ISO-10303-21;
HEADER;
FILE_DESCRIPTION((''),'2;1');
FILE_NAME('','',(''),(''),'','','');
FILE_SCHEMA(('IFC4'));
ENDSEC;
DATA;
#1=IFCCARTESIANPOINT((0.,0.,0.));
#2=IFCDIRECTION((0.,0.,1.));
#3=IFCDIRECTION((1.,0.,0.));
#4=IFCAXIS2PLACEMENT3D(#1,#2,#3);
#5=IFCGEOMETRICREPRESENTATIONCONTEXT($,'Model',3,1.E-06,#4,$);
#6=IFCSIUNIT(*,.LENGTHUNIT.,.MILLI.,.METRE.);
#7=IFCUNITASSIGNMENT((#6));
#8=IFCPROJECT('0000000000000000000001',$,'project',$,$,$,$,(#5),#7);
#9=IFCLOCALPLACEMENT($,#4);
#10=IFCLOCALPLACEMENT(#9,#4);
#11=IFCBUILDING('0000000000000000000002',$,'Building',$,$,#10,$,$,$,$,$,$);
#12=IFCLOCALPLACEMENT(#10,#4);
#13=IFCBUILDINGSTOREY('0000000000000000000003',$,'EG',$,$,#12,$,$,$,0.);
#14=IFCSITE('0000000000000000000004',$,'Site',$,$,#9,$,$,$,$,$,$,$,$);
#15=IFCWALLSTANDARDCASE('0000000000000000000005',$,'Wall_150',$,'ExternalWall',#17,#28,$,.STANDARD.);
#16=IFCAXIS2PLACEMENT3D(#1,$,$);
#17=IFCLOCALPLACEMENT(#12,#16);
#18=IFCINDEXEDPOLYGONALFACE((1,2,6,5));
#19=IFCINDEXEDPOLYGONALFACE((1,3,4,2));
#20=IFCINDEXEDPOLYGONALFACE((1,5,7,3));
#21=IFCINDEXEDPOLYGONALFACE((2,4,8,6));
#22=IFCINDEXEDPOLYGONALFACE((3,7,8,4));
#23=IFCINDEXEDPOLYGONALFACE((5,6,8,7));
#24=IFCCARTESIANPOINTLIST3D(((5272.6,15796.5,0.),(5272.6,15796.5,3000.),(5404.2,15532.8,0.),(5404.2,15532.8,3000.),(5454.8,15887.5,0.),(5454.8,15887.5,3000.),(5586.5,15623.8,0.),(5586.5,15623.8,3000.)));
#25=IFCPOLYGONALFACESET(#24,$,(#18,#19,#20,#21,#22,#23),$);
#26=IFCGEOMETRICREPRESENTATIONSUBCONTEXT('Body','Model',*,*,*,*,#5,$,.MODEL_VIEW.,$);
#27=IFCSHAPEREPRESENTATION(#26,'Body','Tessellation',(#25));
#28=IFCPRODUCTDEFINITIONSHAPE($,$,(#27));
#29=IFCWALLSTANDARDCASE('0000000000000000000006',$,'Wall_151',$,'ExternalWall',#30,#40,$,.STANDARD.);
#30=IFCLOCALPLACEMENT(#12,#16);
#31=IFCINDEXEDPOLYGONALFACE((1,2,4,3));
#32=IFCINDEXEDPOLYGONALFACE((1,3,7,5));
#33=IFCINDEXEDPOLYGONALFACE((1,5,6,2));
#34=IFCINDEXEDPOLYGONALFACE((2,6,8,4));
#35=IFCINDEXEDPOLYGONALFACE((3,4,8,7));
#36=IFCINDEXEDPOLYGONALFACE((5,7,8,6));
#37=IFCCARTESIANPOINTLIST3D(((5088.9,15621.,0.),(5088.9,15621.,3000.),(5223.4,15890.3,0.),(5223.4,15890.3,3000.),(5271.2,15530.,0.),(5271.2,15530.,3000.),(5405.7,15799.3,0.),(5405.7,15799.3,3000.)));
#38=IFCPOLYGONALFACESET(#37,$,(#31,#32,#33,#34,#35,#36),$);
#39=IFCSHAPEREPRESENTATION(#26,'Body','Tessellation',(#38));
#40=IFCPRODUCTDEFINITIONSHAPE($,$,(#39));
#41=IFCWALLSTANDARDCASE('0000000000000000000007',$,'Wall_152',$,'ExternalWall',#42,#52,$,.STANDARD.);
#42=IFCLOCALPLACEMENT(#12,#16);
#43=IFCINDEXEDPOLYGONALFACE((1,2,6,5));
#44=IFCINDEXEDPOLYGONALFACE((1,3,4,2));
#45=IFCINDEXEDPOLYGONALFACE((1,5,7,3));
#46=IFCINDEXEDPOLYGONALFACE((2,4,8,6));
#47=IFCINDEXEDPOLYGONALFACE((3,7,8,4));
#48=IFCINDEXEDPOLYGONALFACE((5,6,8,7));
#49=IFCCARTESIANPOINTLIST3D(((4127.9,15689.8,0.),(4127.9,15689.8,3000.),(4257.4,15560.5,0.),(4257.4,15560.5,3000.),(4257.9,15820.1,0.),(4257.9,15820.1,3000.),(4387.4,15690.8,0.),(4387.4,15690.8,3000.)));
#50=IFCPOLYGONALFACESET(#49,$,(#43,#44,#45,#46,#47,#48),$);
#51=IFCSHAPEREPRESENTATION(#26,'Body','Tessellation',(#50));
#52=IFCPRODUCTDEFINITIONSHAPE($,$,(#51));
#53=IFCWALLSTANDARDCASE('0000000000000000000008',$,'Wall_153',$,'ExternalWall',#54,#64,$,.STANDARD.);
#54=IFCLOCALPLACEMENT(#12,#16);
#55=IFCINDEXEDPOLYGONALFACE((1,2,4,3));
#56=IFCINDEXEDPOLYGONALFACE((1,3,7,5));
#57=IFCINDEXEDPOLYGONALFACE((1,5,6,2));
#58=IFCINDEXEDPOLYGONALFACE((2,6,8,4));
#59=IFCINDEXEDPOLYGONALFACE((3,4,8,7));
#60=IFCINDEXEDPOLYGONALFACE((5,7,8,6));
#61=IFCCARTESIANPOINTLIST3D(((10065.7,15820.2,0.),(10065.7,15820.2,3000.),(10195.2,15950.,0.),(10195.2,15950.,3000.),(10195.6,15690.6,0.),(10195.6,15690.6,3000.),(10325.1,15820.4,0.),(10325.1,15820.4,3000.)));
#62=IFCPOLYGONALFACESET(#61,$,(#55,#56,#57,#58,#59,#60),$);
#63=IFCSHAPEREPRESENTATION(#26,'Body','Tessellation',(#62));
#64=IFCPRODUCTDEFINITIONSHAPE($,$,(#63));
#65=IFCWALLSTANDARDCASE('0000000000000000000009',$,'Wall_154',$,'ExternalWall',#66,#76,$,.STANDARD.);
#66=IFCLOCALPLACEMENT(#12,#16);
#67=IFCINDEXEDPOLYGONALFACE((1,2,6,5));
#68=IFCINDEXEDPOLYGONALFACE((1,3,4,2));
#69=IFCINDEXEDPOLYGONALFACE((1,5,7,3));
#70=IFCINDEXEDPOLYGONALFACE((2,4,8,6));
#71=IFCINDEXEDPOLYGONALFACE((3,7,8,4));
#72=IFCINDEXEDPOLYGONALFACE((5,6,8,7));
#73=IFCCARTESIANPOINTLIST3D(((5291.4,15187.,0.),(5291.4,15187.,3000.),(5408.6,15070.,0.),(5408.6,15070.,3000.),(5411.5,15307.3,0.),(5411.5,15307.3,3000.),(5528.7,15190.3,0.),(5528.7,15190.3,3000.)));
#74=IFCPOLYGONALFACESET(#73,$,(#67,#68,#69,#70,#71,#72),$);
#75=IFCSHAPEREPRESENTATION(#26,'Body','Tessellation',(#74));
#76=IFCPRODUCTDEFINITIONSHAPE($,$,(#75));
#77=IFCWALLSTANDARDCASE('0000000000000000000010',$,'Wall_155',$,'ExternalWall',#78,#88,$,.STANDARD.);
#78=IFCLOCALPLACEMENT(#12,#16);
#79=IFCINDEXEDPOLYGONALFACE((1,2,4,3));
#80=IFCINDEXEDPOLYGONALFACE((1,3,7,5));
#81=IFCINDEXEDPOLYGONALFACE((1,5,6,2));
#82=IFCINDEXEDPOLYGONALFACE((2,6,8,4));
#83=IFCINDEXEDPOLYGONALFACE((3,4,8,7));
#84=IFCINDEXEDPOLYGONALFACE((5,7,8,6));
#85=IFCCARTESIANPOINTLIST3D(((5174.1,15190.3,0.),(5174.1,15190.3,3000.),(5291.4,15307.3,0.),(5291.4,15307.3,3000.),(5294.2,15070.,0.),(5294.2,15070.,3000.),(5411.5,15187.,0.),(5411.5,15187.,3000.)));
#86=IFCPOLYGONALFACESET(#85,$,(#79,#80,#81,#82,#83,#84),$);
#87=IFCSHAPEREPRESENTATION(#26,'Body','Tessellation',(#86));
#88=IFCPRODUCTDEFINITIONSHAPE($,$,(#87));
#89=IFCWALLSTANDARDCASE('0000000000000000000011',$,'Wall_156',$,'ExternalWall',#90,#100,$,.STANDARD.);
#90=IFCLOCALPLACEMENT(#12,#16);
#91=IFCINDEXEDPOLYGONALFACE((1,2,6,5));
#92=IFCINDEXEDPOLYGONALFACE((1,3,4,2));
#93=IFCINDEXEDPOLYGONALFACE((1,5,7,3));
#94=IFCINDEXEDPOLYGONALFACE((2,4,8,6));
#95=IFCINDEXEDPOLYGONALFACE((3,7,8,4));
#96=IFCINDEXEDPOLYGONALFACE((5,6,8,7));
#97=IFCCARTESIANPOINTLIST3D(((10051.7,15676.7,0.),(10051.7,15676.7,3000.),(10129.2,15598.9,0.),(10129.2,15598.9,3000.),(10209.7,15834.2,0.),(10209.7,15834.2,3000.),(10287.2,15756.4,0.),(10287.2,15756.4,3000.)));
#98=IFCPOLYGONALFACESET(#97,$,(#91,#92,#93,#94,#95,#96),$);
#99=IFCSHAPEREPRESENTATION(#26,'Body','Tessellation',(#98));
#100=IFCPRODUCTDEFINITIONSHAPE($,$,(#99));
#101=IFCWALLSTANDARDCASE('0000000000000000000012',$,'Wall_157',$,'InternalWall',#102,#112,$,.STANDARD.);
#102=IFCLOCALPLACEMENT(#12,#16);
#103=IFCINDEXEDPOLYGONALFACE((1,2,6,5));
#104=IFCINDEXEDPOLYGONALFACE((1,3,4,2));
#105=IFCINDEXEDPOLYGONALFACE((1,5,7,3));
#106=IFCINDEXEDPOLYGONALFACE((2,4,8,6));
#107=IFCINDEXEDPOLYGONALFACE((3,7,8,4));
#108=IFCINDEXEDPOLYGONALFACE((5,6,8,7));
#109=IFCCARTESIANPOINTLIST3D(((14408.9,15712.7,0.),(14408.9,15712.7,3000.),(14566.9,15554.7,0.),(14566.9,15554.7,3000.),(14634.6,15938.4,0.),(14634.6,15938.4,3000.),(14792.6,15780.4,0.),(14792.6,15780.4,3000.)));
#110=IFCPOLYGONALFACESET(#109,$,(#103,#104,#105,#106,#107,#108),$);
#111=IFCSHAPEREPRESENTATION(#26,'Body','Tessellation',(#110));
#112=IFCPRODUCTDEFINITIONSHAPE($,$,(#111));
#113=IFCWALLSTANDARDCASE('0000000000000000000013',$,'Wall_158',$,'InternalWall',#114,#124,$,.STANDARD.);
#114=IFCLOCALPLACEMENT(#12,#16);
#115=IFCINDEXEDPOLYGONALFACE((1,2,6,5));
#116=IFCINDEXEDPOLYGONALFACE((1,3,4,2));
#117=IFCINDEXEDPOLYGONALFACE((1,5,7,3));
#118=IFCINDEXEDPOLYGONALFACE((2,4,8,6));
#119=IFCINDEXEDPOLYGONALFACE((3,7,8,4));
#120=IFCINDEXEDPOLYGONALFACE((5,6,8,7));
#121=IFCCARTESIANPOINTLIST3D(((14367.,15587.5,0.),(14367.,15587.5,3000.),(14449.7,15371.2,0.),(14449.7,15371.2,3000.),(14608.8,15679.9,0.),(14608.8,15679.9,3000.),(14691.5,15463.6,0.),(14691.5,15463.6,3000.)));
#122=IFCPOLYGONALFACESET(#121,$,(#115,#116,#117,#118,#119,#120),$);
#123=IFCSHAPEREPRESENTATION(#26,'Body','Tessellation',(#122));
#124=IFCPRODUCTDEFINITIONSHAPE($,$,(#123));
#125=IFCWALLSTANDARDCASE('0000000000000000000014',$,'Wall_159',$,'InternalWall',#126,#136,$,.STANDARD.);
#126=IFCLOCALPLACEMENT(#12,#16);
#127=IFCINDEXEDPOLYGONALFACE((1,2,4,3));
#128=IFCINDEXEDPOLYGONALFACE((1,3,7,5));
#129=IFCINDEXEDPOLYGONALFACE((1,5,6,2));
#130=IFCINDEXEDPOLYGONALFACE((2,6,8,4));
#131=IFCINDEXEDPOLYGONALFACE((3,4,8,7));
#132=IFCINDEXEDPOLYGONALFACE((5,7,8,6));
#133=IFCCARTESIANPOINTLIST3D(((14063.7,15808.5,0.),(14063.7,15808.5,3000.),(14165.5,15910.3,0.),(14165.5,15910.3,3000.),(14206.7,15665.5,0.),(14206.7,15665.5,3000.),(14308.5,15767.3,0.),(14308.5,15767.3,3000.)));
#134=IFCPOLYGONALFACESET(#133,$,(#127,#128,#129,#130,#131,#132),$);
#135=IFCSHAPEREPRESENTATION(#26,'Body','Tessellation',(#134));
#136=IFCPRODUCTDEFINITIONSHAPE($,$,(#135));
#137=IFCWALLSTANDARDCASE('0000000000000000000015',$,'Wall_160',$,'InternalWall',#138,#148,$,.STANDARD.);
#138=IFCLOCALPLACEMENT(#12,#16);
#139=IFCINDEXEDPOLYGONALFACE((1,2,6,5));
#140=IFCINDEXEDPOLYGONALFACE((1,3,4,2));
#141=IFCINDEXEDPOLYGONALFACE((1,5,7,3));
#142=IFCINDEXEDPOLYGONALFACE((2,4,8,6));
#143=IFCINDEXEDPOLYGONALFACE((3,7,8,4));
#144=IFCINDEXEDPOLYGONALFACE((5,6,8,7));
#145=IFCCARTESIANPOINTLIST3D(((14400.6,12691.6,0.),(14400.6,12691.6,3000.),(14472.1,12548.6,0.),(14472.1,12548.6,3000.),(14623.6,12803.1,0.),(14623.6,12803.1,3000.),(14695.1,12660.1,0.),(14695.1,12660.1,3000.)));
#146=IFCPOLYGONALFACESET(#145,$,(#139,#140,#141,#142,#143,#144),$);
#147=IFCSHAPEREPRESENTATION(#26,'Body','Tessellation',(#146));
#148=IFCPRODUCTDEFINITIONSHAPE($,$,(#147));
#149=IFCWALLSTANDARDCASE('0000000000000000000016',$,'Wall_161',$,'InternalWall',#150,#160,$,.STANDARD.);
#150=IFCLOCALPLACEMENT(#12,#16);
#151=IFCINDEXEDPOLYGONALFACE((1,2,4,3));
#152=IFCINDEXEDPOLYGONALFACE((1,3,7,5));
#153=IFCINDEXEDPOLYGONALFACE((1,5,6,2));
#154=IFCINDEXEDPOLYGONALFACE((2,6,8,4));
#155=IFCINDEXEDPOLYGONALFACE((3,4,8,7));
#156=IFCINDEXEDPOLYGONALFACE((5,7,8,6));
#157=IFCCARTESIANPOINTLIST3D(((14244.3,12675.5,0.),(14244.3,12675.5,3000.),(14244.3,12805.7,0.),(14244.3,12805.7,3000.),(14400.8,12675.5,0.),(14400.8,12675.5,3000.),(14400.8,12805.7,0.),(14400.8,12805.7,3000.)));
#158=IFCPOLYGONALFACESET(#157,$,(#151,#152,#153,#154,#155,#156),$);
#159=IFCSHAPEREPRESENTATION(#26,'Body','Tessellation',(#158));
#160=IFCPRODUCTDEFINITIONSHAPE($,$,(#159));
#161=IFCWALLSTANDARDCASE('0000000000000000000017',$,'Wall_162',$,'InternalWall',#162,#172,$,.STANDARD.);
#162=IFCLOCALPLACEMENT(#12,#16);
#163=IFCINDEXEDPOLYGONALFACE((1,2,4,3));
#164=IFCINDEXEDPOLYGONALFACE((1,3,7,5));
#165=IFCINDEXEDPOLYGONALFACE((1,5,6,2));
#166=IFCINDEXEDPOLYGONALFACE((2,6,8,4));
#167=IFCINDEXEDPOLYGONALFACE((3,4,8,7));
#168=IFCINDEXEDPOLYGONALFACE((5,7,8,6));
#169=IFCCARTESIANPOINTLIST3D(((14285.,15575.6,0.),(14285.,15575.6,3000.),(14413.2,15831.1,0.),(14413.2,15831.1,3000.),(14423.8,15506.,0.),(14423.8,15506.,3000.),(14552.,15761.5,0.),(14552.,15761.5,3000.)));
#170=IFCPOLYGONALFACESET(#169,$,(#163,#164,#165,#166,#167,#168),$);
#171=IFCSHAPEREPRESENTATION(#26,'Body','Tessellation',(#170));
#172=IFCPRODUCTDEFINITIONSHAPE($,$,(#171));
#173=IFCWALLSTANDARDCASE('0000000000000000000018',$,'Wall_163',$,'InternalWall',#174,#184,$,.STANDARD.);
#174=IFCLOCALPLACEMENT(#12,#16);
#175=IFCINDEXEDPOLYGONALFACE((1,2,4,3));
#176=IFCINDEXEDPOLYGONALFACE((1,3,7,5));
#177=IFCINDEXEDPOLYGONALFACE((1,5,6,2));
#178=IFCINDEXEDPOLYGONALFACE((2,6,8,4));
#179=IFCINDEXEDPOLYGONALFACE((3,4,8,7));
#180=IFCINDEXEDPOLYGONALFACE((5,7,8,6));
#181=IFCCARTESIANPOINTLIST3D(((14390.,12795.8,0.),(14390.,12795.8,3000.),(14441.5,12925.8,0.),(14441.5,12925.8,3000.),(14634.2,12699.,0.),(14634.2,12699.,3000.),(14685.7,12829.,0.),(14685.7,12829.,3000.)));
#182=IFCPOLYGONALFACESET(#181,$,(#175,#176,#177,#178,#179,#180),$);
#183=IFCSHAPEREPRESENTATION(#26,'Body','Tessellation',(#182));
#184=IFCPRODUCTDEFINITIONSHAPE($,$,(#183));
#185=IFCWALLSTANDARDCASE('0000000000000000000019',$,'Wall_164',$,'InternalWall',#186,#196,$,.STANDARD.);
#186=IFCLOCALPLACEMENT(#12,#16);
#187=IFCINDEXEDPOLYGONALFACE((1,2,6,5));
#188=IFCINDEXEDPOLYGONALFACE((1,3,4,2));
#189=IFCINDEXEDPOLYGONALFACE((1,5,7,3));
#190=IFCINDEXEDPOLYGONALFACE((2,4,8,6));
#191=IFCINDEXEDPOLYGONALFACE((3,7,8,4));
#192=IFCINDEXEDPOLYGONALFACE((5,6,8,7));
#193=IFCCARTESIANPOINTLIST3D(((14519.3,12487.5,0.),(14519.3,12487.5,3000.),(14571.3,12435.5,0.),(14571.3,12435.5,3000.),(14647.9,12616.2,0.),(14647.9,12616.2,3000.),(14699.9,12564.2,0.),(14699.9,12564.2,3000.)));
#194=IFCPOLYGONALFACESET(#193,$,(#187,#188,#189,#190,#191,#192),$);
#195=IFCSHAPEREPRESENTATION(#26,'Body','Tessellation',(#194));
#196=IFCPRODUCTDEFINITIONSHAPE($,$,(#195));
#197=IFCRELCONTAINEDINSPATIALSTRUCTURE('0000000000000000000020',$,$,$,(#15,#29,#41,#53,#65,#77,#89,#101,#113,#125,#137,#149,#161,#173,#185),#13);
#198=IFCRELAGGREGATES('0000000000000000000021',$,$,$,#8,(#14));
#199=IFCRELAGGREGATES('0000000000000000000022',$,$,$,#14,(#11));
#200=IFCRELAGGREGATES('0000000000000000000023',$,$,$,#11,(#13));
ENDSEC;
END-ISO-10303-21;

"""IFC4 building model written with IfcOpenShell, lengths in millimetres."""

from ifc_helpers import new_model, si_unit, frame, origin_with_axes, place, context, subcontext, project, spatial, rectangle, extrude, element, save


model = new_model("IFC4")

# Units and contexts
model_context = context("Model", 3, precision=1e-06, world=origin_with_axes())
body_context = subcontext(model_context, "Body", "Model", "MODEL_VIEW")
ifc_project = project(units=[si_unit("LENGTHUNIT", "METRE", prefix="MILLI")], contexts=[model_context])

# Site, building, storey
site_placement = place(None, origin_with_axes())
site = spatial("IfcSite", under=ifc_project, at=site_placement, Name="Site")
building_placement = place(site_placement, origin_with_axes())
building = spatial("IfcBuilding", under=site, at=building_placement, Name="Building")
storey_placement = place(building_placement, origin_with_axes())
storey = spatial("IfcBuildingStorey", under=building, at=storey_placement, Name="EG", Elevation=0.0)

# Walls
wall_1_placement = place(storey_placement, origin_with_axes())
element("IfcWallStandardCase", 1, at=wall_1_placement, inside=storey, Name="Wall_150", ObjectType="ExternalWall", PredefinedType="STANDARD", context=body_context, shape_type="SweptSolid", body=[
    extrude(rectangle(XDim=203.7, YDim=294.7), frame((5429.5, 15710.2, 0.0), z_axis=(0.0, 0.0, 1.0), x_axis=(-0.894673, -0.446723, 0.0)), (0.0, 0.0, 1.0), 3000.0),
])
wall_2_placement = place(storey_placement, origin_with_axes())
element("IfcWallStandardCase", 2, at=wall_2_placement, inside=storey, Name="Wall_151", ObjectType="ExternalWall", PredefinedType="STANDARD", context=body_context, shape_type="SweptSolid", body=[
    extrude(rectangle(XDim=203.7, YDim=301.1), frame((5247.3, 15710.2, 0.0), z_axis=(0.0, 0.0, 1.0), x_axis=(-0.894673, 0.446723, 0.0)), (0.0, 0.0, 1.0), 3000.0),
])
wall_3_placement = place(storey_placement, origin_with_axes())
element("IfcWallStandardCase", 3, at=wall_3_placement, inside=storey, Name="Wall_152", ObjectType="ExternalWall", PredefinedType="STANDARD", context=body_context, shape_type="SweptSolid", body=[
    extrude(rectangle(XDim=184.0, YDim=183.0), frame((4257.7, 15690.3, 0.0), z_axis=(0.0, 0.0, 1.0), x_axis=(-0.706427, -0.707786, 0.0)), (0.0, 0.0, 1.0), 3000.0),
])
wall_4_placement = place(storey_placement, origin_with_axes())
element("IfcWallStandardCase", 4, at=wall_4_placement, inside=storey, Name="Wall_153", ObjectType="ExternalWall", PredefinedType="STANDARD", context=body_context, shape_type="SweptSolid", body=[
    extrude(rectangle(XDim=183.3, YDim=183.5), frame((10195.4, 15820.3, 0.0), z_axis=(0.0, 0.0, 1.0), x_axis=(0.706425, 0.707788, 0.0)), (0.0, 0.0, 1.0), 3000.0),
])
wall_5_placement = place(storey_placement, origin_with_axes())
element("IfcWallStandardCase", 5, at=wall_5_placement, inside=storey, Name="Wall_154", ObjectType="ExternalWall", PredefinedType="STANDARD", context=body_context, shape_type="SweptSolid", body=[
    extrude(rectangle(XDim=165.6, YDim=170.0), frame((5410.0, 15188.7, 0.0), z_axis=(0.0, 0.0, 1.0), x_axis=(0.707861, -0.706352, 0.0)), (0.0, 0.0, 1.0), 3000.0),
])
wall_6_placement = place(storey_placement, origin_with_axes())
element("IfcWallStandardCase", 6, at=wall_6_placement, inside=storey, Name="Wall_155", ObjectType="ExternalWall", PredefinedType="STANDARD", context=body_context, shape_type="SweptSolid", body=[
    extrude(rectangle(XDim=165.6, YDim=170.0), frame((5292.8, 15188.7, 0.0), z_axis=(0.0, 0.0, 1.0), x_axis=(-0.707861, -0.706352, 0.0)), (0.0, 0.0, 1.0), 3000.0),
])
wall_7_placement = place(storey_placement, origin_with_axes())
element("IfcWallStandardCase", 7, at=wall_7_placement, inside=storey, Name="Wall_156", ObjectType="ExternalWall", PredefinedType="STANDARD", context=body_context, shape_type="SweptSolid", body=[
    extrude(rectangle(XDim=109.8, YDim=223.1), frame((10169.4, 15716.5, 0.0), z_axis=(0.0, 0.0, 1.0), x_axis=(0.705967, -0.708245, 0.0)), (0.0, 0.0, 1.0), 3000.0),
])
wall_8_placement = place(storey_placement, origin_with_axes())
element("IfcWallStandardCase", 8, at=wall_8_placement, inside=storey, Name="Wall_157", ObjectType="InternalWall", PredefinedType="STANDARD", context=body_context, shape_type="SweptSolid", body=[
    extrude(rectangle(XDim=319.1, YDim=223.5), frame((14600.8, 15746.5, 0.0), z_axis=(0.0, 0.0, 1.0), x_axis=(-0.707107, -0.707107, 0.0)), (0.0, 0.0, 1.0), 3000.0),
])
wall_9_placement = place(storey_placement, origin_with_axes())
element("IfcWallStandardCase", 9, at=wall_9_placement, inside=storey, Name="Wall_158", ObjectType="InternalWall", PredefinedType="STANDARD", context=body_context, shape_type="SweptSolid", body=[
    extrude(rectangle(XDim=231.6, YDim=258.8), frame((14529.2, 15525.5, 0.0), z_axis=(0.0, 0.0, 1.0), x_axis=(0.356953, -0.934122, 0.0)), (0.0, 0.0, 1.0), 3000.0),
])
wall_10_placement = place(storey_placement, origin_with_axes())
element("IfcWallStandardCase", 10, at=wall_10_placement, inside=storey, Name="Wall_159", ObjectType="InternalWall", PredefinedType="STANDARD", context=body_context, shape_type="SweptSolid", body=[
    extrude(rectangle(XDim=202.2, YDim=144.0), frame((14186.1, 15787.9, 0.0), z_axis=(0.0, 0.0, 1.0), x_axis=(-0.707107, 0.707107, 0.0)), (0.0, 0.0, 1.0), 3000.0),
])
wall_11_placement = place(storey_placement, origin_with_axes())
element("IfcWallStandardCase", 11, at=wall_11_placement, inside=storey, Name="Wall_160", ObjectType="InternalWall", PredefinedType="STANDARD", context=body_context, shape_type="SweptSolid", body=[
    extrude(rectangle(XDim=159.9, YDim=249.3), frame((14547.8, 12675.9, 0.0), z_axis=(0.0, 0.0, 1.0), x_axis=(-0.447214, 0.894427, 0.0)), (0.0, 0.0, 1.0), 3000.0),
])
wall_12_placement = place(storey_placement, origin_with_axes())
element("IfcWallStandardCase", 12, at=wall_12_placement, inside=storey, Name="Wall_161", ObjectType="InternalWall", PredefinedType="STANDARD", context=body_context, shape_type="SweptSolid", body=[
    extrude(rectangle(XDim=156.5, YDim=130.2), frame((14322.6, 12740.6, 0.0), z_axis=(0.0, 0.0, 1.0), x_axis=(-1.0, 0.0, 0.0)), (0.0, 0.0, 1.0), 3000.0),
])
wall_13_placement = place(storey_placement, origin_with_axes())
element("IfcWallStandardCase", 13, at=wall_13_placement, inside=storey, Name="Wall_162", ObjectType="InternalWall", PredefinedType="STANDARD", context=body_context, shape_type="SweptSolid", body=[
    extrude(rectangle(XDim=155.3, YDim=285.9), frame((14418.5, 15668.5, 0.0), z_axis=(0.0, 0.0, 1.0), x_axis=(-0.893782, 0.448501, 0.0)), (0.0, 0.0, 1.0), 3000.0),
])
wall_14_placement = place(storey_placement, origin_with_axes())
element("IfcWallStandardCase", 14, at=wall_14_placement, inside=storey, Name="Wall_163", ObjectType="InternalWall", PredefinedType="STANDARD", context=body_context, shape_type="SweptSolid", body=[
    extrude(rectangle(XDim=139.8, YDim=262.7), frame((14537.8, 12812.4, 0.0), z_axis=(0.0, 0.0, 1.0), x_axis=(0.368306, 0.929705, 0.0)), (0.0, 0.0, 1.0), 3000.0),
])
wall_15_placement = place(storey_placement, origin_with_axes())
element("IfcWallStandardCase", 15, at=wall_15_placement, inside=storey, Name="Wall_164", ObjectType="InternalWall", PredefinedType="STANDARD", context=body_context, shape_type="SweptSolid", body=[
    extrude(rectangle(XDim=73.5, YDim=182.0), frame((14609.6, 12525.9, 0.0), z_axis=(0.0, 0.0, 1.0), x_axis=(0.707107, -0.707107, 0.0)), (0.0, 0.0, 1.0), 3000.0),
])

save(model, "model.ifc")
